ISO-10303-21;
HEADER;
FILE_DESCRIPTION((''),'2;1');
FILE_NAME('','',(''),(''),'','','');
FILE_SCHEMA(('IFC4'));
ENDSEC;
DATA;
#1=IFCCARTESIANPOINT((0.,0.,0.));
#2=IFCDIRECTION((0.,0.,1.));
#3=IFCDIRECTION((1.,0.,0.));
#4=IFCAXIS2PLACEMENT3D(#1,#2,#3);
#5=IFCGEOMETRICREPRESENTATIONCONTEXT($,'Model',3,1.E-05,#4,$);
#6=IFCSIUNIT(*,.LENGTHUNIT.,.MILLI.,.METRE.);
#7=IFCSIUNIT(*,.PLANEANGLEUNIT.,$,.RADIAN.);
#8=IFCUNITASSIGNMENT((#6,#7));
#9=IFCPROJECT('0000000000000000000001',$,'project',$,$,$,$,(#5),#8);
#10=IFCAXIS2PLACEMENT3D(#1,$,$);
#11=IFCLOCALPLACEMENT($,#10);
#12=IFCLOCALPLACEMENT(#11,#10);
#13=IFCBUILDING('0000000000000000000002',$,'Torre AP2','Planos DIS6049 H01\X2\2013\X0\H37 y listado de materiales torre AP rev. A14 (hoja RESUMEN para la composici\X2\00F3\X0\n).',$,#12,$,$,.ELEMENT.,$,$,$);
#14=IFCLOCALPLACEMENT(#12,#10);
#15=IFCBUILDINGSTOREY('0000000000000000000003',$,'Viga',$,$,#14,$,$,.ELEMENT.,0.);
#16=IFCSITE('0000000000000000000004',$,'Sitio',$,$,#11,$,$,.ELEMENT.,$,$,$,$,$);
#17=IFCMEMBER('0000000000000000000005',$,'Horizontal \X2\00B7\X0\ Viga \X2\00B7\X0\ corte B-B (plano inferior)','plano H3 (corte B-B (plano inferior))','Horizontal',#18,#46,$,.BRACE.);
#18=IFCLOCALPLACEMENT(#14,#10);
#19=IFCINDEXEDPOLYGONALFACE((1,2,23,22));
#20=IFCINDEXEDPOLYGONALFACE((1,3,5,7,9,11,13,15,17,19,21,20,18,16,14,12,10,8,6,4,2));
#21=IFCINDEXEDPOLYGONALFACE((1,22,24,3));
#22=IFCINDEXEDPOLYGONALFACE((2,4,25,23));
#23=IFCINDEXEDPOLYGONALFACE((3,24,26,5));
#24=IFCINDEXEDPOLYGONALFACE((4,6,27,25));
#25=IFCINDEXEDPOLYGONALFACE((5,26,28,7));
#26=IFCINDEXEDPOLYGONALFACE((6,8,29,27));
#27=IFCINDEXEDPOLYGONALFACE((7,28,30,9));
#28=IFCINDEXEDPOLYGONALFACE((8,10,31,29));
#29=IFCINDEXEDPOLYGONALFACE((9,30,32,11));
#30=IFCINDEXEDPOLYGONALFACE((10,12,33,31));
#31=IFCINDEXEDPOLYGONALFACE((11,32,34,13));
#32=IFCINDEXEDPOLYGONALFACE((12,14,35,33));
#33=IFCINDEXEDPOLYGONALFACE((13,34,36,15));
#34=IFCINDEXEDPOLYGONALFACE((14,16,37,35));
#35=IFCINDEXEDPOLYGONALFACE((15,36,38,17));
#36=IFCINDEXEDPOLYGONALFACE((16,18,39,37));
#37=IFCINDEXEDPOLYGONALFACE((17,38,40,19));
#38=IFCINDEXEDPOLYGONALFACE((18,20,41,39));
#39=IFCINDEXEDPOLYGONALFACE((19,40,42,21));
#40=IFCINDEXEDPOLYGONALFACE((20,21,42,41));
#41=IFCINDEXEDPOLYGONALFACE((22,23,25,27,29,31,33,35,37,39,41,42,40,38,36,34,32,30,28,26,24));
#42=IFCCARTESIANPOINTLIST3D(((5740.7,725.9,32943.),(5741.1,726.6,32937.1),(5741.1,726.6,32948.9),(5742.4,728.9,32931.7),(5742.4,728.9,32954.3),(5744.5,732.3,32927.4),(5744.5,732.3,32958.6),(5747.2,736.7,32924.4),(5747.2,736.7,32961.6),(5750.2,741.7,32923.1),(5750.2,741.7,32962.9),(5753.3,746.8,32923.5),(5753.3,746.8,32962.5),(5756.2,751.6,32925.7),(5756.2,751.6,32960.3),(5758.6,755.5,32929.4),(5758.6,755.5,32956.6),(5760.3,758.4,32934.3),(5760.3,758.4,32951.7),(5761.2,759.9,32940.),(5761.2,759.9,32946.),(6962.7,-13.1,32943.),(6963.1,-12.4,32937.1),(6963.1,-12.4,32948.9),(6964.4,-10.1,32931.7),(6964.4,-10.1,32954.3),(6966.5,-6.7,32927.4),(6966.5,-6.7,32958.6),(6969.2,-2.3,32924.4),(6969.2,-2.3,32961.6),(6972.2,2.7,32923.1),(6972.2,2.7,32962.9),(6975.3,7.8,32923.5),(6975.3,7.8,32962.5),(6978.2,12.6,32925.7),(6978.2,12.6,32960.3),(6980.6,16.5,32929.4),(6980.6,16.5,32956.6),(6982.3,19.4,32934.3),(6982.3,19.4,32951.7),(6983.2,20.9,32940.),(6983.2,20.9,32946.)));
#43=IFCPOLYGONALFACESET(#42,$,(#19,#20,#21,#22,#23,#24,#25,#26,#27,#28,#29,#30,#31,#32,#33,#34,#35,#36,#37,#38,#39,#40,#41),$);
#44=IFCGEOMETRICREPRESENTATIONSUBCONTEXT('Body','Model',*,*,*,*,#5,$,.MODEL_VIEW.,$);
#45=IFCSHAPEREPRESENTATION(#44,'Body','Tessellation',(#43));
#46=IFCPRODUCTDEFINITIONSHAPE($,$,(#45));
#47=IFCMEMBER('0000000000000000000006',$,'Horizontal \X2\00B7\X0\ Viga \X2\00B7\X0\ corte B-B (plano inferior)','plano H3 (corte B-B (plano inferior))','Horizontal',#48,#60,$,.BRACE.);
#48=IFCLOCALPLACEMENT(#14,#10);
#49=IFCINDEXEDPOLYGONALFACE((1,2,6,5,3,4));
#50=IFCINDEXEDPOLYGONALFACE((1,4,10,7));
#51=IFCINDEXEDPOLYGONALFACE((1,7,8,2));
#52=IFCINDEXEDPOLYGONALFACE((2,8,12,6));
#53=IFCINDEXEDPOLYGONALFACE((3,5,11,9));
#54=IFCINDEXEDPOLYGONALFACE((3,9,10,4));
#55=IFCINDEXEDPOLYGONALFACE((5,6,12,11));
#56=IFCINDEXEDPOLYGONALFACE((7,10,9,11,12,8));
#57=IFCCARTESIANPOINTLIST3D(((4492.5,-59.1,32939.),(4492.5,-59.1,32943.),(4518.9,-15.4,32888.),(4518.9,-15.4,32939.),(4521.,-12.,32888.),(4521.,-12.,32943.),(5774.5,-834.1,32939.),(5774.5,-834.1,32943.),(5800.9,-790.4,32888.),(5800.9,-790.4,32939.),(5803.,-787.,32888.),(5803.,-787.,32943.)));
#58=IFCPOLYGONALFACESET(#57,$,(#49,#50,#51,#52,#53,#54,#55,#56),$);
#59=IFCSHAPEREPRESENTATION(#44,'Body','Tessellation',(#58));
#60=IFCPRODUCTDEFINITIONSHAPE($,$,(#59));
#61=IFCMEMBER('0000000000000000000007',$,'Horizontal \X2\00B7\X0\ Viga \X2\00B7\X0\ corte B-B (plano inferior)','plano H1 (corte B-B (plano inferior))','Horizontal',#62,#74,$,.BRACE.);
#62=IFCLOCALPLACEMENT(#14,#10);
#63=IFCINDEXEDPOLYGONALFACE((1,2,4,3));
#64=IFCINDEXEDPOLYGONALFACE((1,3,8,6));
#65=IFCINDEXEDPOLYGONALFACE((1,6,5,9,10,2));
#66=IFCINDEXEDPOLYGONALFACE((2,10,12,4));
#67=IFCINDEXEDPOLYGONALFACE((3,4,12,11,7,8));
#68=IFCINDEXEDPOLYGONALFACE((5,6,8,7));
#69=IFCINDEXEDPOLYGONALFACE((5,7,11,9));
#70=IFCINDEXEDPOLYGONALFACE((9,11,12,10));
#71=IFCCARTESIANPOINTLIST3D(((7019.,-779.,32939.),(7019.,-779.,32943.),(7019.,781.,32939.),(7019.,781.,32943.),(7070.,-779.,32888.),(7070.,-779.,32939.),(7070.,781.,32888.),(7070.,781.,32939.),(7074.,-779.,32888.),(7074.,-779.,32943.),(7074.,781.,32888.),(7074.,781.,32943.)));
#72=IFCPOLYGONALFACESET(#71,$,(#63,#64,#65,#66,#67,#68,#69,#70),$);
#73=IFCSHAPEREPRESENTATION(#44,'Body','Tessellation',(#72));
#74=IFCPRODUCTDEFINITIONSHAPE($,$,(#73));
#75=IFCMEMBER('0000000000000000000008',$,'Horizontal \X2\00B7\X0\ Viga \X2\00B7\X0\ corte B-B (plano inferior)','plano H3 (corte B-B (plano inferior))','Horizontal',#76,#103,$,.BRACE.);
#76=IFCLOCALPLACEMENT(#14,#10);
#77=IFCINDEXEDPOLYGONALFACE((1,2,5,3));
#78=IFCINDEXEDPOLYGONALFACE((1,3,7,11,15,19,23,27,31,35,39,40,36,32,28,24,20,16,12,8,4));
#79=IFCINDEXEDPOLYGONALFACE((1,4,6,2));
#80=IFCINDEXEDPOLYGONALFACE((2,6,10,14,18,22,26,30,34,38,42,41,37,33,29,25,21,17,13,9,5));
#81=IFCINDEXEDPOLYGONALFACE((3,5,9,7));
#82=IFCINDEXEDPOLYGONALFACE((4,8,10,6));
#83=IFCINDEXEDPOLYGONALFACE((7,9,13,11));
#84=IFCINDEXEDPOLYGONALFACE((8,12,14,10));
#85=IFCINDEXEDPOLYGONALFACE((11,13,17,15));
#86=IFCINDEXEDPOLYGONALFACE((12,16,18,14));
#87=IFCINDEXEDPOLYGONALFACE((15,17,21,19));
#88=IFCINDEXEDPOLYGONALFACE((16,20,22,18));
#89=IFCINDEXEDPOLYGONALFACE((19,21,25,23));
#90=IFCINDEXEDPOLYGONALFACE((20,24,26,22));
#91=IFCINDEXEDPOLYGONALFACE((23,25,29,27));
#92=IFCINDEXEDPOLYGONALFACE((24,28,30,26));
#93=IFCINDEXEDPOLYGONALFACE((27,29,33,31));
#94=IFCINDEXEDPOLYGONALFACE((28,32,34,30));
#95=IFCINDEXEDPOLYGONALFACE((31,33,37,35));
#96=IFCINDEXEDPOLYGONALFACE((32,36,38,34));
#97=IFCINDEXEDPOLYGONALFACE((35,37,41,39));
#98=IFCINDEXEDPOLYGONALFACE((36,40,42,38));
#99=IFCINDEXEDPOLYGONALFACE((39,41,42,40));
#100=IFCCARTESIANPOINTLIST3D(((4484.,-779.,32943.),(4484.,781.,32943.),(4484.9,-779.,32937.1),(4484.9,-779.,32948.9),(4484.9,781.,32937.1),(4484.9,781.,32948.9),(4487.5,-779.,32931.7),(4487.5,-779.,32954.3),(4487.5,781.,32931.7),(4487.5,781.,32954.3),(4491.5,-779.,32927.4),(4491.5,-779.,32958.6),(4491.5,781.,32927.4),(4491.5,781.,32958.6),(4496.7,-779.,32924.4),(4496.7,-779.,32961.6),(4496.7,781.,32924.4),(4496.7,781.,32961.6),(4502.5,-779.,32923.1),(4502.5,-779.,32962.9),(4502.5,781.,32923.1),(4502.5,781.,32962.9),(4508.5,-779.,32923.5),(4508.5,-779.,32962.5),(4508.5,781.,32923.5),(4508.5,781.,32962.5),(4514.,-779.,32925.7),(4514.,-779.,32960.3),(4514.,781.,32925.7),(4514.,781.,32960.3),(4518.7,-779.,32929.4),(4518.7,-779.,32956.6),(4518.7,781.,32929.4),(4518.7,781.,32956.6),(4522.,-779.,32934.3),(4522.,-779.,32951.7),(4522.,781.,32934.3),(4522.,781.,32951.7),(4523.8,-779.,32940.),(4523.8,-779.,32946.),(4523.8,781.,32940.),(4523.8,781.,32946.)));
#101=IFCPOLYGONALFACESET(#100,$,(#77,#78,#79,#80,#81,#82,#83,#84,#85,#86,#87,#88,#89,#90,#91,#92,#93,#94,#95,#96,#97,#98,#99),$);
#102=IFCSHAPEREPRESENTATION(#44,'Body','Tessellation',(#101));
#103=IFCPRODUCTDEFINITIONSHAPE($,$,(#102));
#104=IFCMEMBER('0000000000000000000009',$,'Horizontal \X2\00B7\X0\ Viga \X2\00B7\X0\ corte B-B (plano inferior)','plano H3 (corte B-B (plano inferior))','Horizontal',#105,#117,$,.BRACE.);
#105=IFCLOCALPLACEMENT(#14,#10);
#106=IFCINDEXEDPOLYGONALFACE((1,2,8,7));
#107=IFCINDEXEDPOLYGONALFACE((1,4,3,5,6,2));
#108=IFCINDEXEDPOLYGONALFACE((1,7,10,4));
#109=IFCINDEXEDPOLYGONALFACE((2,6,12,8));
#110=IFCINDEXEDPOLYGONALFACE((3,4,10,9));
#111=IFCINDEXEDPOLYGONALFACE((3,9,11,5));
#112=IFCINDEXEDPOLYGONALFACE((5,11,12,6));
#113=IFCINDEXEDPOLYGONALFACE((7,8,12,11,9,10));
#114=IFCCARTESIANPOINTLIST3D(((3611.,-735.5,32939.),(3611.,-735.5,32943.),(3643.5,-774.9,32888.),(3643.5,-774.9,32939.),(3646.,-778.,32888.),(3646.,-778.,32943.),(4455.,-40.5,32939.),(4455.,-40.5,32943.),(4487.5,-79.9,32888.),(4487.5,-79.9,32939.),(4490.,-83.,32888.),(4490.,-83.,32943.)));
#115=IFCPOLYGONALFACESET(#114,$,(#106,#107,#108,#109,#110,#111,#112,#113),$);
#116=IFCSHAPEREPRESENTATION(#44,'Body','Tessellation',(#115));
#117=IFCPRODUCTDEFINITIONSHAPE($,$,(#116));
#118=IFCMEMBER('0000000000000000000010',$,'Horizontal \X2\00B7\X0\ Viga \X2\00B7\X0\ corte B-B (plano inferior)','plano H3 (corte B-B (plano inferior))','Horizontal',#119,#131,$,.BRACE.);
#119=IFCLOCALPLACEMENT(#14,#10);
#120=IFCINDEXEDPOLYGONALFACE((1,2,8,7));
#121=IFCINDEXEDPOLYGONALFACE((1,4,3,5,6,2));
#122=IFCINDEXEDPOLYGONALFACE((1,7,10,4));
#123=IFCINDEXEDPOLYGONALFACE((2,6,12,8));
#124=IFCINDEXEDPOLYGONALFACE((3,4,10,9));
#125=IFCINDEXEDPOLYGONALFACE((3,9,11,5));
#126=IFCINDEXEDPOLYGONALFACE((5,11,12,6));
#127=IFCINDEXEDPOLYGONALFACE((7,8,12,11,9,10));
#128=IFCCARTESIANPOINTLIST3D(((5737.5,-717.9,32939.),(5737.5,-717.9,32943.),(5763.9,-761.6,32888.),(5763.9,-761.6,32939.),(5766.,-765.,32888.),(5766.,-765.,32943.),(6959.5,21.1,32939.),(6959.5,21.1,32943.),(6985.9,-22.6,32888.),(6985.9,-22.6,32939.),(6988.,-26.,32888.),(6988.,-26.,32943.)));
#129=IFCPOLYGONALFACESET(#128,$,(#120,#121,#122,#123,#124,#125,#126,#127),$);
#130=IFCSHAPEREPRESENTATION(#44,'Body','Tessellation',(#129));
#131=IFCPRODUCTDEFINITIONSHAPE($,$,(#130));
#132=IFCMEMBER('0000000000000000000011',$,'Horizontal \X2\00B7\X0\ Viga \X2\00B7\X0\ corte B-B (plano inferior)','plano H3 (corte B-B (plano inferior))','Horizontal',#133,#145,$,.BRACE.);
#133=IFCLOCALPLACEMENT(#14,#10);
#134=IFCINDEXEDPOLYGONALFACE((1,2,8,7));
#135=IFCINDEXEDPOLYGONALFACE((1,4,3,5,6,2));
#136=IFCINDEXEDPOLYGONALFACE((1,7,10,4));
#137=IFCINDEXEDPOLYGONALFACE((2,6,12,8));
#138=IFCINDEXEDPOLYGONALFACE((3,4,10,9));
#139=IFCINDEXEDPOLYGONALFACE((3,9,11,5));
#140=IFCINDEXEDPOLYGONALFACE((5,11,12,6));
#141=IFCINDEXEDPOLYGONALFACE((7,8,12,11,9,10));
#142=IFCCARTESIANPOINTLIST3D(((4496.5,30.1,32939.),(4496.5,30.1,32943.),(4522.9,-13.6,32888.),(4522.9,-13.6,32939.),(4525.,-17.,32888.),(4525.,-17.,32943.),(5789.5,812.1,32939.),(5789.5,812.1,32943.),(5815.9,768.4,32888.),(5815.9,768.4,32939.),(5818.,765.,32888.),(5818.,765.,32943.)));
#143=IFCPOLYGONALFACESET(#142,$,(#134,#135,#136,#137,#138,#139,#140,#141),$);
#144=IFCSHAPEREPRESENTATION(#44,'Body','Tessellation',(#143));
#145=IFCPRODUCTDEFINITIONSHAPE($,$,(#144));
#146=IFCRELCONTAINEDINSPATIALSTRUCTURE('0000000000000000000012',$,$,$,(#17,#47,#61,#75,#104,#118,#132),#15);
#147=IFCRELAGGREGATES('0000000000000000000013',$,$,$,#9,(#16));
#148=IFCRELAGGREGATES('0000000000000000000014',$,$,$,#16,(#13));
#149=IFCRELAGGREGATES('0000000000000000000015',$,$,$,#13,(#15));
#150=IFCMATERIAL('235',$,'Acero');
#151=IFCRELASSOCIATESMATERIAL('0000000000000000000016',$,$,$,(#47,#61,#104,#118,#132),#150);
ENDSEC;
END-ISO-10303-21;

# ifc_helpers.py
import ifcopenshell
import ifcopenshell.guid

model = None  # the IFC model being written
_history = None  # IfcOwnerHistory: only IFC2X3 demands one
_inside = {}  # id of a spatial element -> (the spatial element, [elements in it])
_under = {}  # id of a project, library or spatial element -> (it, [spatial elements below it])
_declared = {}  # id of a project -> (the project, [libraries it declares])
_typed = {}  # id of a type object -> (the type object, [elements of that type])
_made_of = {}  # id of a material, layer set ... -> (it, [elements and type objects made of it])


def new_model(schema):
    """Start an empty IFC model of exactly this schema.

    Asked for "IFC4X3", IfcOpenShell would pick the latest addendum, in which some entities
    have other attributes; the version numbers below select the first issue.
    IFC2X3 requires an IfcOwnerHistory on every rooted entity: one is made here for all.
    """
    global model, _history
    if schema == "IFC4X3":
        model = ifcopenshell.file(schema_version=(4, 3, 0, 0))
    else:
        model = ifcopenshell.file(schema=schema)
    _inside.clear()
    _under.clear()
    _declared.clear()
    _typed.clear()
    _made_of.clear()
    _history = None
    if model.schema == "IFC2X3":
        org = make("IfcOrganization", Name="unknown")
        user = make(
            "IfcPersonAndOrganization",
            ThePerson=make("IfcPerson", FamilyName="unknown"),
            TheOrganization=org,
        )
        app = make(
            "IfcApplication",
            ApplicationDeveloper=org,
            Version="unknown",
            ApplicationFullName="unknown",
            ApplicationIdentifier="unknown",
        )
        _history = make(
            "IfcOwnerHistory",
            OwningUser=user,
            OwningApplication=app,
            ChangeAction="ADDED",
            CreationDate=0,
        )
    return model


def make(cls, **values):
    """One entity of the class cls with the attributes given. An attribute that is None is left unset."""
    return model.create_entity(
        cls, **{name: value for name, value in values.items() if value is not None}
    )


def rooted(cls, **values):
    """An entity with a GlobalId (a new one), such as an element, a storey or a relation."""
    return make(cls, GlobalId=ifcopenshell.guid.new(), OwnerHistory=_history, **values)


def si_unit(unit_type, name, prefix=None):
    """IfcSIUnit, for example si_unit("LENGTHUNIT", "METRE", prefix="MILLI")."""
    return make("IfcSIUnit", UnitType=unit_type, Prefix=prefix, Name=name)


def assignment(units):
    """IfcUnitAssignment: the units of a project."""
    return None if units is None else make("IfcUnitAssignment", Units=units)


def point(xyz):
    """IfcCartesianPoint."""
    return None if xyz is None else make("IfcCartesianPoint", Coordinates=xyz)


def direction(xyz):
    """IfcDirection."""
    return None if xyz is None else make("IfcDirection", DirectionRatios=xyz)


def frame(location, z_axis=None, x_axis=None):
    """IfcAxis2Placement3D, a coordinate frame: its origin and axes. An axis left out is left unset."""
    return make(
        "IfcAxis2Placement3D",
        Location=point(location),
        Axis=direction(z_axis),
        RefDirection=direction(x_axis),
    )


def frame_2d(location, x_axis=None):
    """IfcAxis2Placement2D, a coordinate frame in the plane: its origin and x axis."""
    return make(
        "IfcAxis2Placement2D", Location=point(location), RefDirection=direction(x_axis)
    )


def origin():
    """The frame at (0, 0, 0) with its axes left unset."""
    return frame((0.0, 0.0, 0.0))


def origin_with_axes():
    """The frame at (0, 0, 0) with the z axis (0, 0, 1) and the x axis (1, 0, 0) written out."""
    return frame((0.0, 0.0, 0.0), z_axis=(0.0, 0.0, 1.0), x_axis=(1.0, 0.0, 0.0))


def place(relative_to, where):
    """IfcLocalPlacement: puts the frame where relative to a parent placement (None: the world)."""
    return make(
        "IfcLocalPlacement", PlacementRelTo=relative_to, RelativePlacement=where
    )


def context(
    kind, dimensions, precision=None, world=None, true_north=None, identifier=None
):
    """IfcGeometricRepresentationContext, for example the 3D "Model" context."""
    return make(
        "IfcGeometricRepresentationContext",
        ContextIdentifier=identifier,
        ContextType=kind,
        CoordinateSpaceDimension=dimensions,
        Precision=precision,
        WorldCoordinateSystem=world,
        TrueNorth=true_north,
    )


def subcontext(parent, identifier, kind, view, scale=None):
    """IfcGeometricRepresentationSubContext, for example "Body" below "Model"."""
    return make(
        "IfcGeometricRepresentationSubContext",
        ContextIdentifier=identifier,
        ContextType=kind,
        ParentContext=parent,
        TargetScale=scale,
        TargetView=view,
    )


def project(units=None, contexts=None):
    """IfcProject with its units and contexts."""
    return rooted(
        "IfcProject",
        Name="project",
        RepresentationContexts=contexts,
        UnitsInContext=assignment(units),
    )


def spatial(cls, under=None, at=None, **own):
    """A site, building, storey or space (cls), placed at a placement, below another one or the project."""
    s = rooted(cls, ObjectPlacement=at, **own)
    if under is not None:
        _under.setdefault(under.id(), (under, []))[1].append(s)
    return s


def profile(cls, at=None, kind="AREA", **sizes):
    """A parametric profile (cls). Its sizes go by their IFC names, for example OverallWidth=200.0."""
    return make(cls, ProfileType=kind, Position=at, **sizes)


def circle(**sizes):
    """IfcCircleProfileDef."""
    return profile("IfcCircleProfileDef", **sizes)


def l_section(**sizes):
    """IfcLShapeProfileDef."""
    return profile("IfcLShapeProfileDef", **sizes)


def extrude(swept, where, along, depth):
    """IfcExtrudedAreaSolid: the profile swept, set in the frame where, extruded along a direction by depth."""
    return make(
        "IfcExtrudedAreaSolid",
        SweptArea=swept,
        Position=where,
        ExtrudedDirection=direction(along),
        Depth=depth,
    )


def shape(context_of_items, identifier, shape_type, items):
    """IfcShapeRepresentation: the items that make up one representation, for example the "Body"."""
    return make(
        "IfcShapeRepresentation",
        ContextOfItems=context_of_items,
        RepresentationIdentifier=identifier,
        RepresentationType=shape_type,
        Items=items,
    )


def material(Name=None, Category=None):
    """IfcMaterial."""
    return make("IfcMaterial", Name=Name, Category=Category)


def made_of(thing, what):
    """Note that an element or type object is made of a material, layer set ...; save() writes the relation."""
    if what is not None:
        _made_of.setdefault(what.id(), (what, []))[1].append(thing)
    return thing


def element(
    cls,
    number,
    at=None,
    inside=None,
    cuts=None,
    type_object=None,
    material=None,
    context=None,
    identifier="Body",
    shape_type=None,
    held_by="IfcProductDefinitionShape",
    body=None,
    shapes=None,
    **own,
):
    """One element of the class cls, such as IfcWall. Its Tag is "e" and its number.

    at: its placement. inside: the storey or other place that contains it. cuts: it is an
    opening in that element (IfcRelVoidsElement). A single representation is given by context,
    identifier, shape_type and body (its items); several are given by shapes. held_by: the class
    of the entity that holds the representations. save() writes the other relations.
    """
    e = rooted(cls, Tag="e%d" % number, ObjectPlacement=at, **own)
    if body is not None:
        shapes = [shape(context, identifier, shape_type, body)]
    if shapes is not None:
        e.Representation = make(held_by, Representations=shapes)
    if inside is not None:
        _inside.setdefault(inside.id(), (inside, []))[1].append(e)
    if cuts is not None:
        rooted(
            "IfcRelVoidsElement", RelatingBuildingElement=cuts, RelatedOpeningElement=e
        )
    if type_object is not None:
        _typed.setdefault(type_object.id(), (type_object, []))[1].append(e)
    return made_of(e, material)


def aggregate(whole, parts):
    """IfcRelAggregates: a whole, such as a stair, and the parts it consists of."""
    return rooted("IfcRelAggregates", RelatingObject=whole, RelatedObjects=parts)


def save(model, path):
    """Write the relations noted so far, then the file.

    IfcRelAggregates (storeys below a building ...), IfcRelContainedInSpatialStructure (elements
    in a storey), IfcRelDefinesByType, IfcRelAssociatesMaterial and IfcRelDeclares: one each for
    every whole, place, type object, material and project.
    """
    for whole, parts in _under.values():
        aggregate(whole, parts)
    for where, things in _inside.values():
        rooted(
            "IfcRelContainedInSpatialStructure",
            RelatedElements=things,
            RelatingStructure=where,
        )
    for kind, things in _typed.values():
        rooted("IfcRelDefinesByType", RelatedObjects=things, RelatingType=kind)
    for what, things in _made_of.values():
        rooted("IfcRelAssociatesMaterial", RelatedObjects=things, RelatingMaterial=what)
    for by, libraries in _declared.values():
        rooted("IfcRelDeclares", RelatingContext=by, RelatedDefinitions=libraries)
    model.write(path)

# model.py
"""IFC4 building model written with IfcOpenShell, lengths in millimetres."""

from ifc_helpers import new_model, si_unit, frame, frame_2d, origin, origin_with_axes, place, context, subcontext, project, spatial, circle, l_section, extrude, material, element, save


model = new_model("IFC4")

# Units and contexts
model_context = context("Model", 3, precision=1e-05, world=origin_with_axes())
body_context = subcontext(model_context, "Body", "Model", "MODEL_VIEW")
ifc_project = project(units=[si_unit("LENGTHUNIT", "METRE", prefix="MILLI"), si_unit("PLANEANGLEUNIT", "RADIAN")], contexts=[model_context])

# Site, building, storey
site_placement = place(None, origin())
site = spatial("IfcSite", under=ifc_project, at=site_placement, Name="Sitio", CompositionType="ELEMENT")
building_placement = place(site_placement, origin())
building = spatial("IfcBuilding", under=site, at=building_placement, Name="Torre AP2", Description="Planos DIS6049 H01–H37 y listado de materiales torre AP rev. A14 (hoja RESUMEN para la composición).", CompositionType="ELEMENT")
storey_placement = place(building_placement, origin())
storey = spatial("IfcBuildingStorey", under=building, at=storey_placement, Name="Viga", CompositionType="ELEMENT", Elevation=0.0)

# Members
ifc_material_1 = material(Name="235", Category="Acero")
member_1_placement = place(storey_placement, frame((5751.0, 743.0, 32943.0), z_axis=(0.855696, -0.517479, 0.0), x_axis=(-0.517479, -0.855696, 0.0)))
element("IfcMember", 1, at=member_1_placement, inside=storey, Name="Horizontal · Viga · corte B-B (plano inferior)", Description="plano H3 (corte B-B (plano inferior))", ObjectType="Horizontal", PredefinedType="BRACE", context=body_context, shape_type="SweptSolid", body=[
    extrude(circle(Radius=20.0), None, (0.0, 0.0, 1.0), 1428.1),
])
member_2_placement = place(storey_placement, frame((4521.0, -12.0, 32943.0), z_axis=(0.85578, -0.51734, 0.0), x_axis=(-0.51734, -0.85578, 0.0)))
element("IfcMember", 2, at=member_2_placement, inside=storey, material=ifc_material_1, Name="Horizontal · Viga · corte B-B (plano inferior)", Description="plano H3 (corte B-B (plano inferior))", ObjectType="Horizontal", PredefinedType="BRACE", context=body_context, shape_type="SweptSolid", body=[
    extrude(l_section(Depth=55.0, Width=55.0, Thickness=4.0, at=frame_2d((27.5, 27.5))), None, (0.0, 0.0, 1.0), 1498.0),
])
member_3_placement = place(storey_placement, frame((7074.0, 781.0, 32943.0), z_axis=(0.0, -1.0, 0.0), x_axis=(-1.0, 0.0, 0.0)))
element("IfcMember", 3, at=member_3_placement, inside=storey, material=ifc_material_1, Name="Horizontal · Viga · corte B-B (plano inferior)", Description="plano H1 (corte B-B (plano inferior))", ObjectType="Horizontal", PredefinedType="BRACE", context=body_context, shape_type="SweptSolid", body=[
    extrude(l_section(Depth=55.0, Width=55.0, Thickness=4.0, at=frame_2d((27.5, 27.5))), None, (0.0, 0.0, 1.0), 1560.0),
])
member_4_placement = place(storey_placement, frame((4504.0, 781.0, 32943.0), z_axis=(0.0, -1.0, 0.0), x_axis=(-1.0, 0.0, 0.0)))
element("IfcMember", 4, at=member_4_placement, inside=storey, Name="Horizontal · Viga · corte B-B (plano inferior)", Description="plano H3 (corte B-B (plano inferior))", ObjectType="Horizontal", PredefinedType="BRACE", context=body_context, shape_type="SweptSolid", body=[
    extrude(circle(Radius=20.0), None, (0.0, 0.0, 1.0), 1560.0),
])
member_5_placement = place(storey_placement, frame((4490.0, -83.0, 32943.0), z_axis=(-0.771957, -0.635675, 0.0), x_axis=(-0.635675, 0.771957, 0.0)))
element("IfcMember", 5, at=member_5_placement, inside=storey, material=ifc_material_1, Name="Horizontal · Viga · corte B-B (plano inferior)", Description="plano H3 (corte B-B (plano inferior))", ObjectType="Horizontal", PredefinedType="BRACE", context=body_context, shape_type="SweptSolid", body=[
    extrude(l_section(Depth=55.0, Width=55.0, Thickness=4.0, at=frame_2d((27.5, 27.5))), None, (0.0, 0.0, 1.0), 1093.3),
])
member_6_placement = place(storey_placement, frame((6988.0, -26.0, 32943.0), z_axis=(-0.855696, -0.517479, 0.0), x_axis=(-0.517479, 0.855696, 0.0)))
element("IfcMember", 6, at=member_6_placement, inside=storey, material=ifc_material_1, Name="Horizontal · Viga · corte B-B (plano inferior)", Description="plano H3 (corte B-B (plano inferior))", ObjectType="Horizontal", PredefinedType="BRACE", context=body_context, shape_type="SweptSolid", body=[
    extrude(l_section(Depth=55.0, Width=55.0, Thickness=4.0, at=frame_2d((27.5, 27.5))), None, (0.0, 0.0, 1.0), 1428.1),
])
member_7_placement = place(storey_placement, frame((5818.0, 765.0, 32943.0), z_axis=(-0.855677, -0.517509, 0.0), x_axis=(-0.517509, 0.855677, 0.0)))
element("IfcMember", 7, at=member_7_placement, inside=storey, material=ifc_material_1, Name="Horizontal · Viga · corte B-B (plano inferior)", Description="plano H3 (corte B-B (plano inferior))", ObjectType="Horizontal", PredefinedType="BRACE", context=body_context, shape_type="SweptSolid", body=[
    extrude(l_section(Depth=55.0, Width=55.0, Thickness=4.0, at=frame_2d((27.5, 27.5))), None, (0.0, 0.0, 1.0), 1511.1),
])

save(model, "model.ifc")
